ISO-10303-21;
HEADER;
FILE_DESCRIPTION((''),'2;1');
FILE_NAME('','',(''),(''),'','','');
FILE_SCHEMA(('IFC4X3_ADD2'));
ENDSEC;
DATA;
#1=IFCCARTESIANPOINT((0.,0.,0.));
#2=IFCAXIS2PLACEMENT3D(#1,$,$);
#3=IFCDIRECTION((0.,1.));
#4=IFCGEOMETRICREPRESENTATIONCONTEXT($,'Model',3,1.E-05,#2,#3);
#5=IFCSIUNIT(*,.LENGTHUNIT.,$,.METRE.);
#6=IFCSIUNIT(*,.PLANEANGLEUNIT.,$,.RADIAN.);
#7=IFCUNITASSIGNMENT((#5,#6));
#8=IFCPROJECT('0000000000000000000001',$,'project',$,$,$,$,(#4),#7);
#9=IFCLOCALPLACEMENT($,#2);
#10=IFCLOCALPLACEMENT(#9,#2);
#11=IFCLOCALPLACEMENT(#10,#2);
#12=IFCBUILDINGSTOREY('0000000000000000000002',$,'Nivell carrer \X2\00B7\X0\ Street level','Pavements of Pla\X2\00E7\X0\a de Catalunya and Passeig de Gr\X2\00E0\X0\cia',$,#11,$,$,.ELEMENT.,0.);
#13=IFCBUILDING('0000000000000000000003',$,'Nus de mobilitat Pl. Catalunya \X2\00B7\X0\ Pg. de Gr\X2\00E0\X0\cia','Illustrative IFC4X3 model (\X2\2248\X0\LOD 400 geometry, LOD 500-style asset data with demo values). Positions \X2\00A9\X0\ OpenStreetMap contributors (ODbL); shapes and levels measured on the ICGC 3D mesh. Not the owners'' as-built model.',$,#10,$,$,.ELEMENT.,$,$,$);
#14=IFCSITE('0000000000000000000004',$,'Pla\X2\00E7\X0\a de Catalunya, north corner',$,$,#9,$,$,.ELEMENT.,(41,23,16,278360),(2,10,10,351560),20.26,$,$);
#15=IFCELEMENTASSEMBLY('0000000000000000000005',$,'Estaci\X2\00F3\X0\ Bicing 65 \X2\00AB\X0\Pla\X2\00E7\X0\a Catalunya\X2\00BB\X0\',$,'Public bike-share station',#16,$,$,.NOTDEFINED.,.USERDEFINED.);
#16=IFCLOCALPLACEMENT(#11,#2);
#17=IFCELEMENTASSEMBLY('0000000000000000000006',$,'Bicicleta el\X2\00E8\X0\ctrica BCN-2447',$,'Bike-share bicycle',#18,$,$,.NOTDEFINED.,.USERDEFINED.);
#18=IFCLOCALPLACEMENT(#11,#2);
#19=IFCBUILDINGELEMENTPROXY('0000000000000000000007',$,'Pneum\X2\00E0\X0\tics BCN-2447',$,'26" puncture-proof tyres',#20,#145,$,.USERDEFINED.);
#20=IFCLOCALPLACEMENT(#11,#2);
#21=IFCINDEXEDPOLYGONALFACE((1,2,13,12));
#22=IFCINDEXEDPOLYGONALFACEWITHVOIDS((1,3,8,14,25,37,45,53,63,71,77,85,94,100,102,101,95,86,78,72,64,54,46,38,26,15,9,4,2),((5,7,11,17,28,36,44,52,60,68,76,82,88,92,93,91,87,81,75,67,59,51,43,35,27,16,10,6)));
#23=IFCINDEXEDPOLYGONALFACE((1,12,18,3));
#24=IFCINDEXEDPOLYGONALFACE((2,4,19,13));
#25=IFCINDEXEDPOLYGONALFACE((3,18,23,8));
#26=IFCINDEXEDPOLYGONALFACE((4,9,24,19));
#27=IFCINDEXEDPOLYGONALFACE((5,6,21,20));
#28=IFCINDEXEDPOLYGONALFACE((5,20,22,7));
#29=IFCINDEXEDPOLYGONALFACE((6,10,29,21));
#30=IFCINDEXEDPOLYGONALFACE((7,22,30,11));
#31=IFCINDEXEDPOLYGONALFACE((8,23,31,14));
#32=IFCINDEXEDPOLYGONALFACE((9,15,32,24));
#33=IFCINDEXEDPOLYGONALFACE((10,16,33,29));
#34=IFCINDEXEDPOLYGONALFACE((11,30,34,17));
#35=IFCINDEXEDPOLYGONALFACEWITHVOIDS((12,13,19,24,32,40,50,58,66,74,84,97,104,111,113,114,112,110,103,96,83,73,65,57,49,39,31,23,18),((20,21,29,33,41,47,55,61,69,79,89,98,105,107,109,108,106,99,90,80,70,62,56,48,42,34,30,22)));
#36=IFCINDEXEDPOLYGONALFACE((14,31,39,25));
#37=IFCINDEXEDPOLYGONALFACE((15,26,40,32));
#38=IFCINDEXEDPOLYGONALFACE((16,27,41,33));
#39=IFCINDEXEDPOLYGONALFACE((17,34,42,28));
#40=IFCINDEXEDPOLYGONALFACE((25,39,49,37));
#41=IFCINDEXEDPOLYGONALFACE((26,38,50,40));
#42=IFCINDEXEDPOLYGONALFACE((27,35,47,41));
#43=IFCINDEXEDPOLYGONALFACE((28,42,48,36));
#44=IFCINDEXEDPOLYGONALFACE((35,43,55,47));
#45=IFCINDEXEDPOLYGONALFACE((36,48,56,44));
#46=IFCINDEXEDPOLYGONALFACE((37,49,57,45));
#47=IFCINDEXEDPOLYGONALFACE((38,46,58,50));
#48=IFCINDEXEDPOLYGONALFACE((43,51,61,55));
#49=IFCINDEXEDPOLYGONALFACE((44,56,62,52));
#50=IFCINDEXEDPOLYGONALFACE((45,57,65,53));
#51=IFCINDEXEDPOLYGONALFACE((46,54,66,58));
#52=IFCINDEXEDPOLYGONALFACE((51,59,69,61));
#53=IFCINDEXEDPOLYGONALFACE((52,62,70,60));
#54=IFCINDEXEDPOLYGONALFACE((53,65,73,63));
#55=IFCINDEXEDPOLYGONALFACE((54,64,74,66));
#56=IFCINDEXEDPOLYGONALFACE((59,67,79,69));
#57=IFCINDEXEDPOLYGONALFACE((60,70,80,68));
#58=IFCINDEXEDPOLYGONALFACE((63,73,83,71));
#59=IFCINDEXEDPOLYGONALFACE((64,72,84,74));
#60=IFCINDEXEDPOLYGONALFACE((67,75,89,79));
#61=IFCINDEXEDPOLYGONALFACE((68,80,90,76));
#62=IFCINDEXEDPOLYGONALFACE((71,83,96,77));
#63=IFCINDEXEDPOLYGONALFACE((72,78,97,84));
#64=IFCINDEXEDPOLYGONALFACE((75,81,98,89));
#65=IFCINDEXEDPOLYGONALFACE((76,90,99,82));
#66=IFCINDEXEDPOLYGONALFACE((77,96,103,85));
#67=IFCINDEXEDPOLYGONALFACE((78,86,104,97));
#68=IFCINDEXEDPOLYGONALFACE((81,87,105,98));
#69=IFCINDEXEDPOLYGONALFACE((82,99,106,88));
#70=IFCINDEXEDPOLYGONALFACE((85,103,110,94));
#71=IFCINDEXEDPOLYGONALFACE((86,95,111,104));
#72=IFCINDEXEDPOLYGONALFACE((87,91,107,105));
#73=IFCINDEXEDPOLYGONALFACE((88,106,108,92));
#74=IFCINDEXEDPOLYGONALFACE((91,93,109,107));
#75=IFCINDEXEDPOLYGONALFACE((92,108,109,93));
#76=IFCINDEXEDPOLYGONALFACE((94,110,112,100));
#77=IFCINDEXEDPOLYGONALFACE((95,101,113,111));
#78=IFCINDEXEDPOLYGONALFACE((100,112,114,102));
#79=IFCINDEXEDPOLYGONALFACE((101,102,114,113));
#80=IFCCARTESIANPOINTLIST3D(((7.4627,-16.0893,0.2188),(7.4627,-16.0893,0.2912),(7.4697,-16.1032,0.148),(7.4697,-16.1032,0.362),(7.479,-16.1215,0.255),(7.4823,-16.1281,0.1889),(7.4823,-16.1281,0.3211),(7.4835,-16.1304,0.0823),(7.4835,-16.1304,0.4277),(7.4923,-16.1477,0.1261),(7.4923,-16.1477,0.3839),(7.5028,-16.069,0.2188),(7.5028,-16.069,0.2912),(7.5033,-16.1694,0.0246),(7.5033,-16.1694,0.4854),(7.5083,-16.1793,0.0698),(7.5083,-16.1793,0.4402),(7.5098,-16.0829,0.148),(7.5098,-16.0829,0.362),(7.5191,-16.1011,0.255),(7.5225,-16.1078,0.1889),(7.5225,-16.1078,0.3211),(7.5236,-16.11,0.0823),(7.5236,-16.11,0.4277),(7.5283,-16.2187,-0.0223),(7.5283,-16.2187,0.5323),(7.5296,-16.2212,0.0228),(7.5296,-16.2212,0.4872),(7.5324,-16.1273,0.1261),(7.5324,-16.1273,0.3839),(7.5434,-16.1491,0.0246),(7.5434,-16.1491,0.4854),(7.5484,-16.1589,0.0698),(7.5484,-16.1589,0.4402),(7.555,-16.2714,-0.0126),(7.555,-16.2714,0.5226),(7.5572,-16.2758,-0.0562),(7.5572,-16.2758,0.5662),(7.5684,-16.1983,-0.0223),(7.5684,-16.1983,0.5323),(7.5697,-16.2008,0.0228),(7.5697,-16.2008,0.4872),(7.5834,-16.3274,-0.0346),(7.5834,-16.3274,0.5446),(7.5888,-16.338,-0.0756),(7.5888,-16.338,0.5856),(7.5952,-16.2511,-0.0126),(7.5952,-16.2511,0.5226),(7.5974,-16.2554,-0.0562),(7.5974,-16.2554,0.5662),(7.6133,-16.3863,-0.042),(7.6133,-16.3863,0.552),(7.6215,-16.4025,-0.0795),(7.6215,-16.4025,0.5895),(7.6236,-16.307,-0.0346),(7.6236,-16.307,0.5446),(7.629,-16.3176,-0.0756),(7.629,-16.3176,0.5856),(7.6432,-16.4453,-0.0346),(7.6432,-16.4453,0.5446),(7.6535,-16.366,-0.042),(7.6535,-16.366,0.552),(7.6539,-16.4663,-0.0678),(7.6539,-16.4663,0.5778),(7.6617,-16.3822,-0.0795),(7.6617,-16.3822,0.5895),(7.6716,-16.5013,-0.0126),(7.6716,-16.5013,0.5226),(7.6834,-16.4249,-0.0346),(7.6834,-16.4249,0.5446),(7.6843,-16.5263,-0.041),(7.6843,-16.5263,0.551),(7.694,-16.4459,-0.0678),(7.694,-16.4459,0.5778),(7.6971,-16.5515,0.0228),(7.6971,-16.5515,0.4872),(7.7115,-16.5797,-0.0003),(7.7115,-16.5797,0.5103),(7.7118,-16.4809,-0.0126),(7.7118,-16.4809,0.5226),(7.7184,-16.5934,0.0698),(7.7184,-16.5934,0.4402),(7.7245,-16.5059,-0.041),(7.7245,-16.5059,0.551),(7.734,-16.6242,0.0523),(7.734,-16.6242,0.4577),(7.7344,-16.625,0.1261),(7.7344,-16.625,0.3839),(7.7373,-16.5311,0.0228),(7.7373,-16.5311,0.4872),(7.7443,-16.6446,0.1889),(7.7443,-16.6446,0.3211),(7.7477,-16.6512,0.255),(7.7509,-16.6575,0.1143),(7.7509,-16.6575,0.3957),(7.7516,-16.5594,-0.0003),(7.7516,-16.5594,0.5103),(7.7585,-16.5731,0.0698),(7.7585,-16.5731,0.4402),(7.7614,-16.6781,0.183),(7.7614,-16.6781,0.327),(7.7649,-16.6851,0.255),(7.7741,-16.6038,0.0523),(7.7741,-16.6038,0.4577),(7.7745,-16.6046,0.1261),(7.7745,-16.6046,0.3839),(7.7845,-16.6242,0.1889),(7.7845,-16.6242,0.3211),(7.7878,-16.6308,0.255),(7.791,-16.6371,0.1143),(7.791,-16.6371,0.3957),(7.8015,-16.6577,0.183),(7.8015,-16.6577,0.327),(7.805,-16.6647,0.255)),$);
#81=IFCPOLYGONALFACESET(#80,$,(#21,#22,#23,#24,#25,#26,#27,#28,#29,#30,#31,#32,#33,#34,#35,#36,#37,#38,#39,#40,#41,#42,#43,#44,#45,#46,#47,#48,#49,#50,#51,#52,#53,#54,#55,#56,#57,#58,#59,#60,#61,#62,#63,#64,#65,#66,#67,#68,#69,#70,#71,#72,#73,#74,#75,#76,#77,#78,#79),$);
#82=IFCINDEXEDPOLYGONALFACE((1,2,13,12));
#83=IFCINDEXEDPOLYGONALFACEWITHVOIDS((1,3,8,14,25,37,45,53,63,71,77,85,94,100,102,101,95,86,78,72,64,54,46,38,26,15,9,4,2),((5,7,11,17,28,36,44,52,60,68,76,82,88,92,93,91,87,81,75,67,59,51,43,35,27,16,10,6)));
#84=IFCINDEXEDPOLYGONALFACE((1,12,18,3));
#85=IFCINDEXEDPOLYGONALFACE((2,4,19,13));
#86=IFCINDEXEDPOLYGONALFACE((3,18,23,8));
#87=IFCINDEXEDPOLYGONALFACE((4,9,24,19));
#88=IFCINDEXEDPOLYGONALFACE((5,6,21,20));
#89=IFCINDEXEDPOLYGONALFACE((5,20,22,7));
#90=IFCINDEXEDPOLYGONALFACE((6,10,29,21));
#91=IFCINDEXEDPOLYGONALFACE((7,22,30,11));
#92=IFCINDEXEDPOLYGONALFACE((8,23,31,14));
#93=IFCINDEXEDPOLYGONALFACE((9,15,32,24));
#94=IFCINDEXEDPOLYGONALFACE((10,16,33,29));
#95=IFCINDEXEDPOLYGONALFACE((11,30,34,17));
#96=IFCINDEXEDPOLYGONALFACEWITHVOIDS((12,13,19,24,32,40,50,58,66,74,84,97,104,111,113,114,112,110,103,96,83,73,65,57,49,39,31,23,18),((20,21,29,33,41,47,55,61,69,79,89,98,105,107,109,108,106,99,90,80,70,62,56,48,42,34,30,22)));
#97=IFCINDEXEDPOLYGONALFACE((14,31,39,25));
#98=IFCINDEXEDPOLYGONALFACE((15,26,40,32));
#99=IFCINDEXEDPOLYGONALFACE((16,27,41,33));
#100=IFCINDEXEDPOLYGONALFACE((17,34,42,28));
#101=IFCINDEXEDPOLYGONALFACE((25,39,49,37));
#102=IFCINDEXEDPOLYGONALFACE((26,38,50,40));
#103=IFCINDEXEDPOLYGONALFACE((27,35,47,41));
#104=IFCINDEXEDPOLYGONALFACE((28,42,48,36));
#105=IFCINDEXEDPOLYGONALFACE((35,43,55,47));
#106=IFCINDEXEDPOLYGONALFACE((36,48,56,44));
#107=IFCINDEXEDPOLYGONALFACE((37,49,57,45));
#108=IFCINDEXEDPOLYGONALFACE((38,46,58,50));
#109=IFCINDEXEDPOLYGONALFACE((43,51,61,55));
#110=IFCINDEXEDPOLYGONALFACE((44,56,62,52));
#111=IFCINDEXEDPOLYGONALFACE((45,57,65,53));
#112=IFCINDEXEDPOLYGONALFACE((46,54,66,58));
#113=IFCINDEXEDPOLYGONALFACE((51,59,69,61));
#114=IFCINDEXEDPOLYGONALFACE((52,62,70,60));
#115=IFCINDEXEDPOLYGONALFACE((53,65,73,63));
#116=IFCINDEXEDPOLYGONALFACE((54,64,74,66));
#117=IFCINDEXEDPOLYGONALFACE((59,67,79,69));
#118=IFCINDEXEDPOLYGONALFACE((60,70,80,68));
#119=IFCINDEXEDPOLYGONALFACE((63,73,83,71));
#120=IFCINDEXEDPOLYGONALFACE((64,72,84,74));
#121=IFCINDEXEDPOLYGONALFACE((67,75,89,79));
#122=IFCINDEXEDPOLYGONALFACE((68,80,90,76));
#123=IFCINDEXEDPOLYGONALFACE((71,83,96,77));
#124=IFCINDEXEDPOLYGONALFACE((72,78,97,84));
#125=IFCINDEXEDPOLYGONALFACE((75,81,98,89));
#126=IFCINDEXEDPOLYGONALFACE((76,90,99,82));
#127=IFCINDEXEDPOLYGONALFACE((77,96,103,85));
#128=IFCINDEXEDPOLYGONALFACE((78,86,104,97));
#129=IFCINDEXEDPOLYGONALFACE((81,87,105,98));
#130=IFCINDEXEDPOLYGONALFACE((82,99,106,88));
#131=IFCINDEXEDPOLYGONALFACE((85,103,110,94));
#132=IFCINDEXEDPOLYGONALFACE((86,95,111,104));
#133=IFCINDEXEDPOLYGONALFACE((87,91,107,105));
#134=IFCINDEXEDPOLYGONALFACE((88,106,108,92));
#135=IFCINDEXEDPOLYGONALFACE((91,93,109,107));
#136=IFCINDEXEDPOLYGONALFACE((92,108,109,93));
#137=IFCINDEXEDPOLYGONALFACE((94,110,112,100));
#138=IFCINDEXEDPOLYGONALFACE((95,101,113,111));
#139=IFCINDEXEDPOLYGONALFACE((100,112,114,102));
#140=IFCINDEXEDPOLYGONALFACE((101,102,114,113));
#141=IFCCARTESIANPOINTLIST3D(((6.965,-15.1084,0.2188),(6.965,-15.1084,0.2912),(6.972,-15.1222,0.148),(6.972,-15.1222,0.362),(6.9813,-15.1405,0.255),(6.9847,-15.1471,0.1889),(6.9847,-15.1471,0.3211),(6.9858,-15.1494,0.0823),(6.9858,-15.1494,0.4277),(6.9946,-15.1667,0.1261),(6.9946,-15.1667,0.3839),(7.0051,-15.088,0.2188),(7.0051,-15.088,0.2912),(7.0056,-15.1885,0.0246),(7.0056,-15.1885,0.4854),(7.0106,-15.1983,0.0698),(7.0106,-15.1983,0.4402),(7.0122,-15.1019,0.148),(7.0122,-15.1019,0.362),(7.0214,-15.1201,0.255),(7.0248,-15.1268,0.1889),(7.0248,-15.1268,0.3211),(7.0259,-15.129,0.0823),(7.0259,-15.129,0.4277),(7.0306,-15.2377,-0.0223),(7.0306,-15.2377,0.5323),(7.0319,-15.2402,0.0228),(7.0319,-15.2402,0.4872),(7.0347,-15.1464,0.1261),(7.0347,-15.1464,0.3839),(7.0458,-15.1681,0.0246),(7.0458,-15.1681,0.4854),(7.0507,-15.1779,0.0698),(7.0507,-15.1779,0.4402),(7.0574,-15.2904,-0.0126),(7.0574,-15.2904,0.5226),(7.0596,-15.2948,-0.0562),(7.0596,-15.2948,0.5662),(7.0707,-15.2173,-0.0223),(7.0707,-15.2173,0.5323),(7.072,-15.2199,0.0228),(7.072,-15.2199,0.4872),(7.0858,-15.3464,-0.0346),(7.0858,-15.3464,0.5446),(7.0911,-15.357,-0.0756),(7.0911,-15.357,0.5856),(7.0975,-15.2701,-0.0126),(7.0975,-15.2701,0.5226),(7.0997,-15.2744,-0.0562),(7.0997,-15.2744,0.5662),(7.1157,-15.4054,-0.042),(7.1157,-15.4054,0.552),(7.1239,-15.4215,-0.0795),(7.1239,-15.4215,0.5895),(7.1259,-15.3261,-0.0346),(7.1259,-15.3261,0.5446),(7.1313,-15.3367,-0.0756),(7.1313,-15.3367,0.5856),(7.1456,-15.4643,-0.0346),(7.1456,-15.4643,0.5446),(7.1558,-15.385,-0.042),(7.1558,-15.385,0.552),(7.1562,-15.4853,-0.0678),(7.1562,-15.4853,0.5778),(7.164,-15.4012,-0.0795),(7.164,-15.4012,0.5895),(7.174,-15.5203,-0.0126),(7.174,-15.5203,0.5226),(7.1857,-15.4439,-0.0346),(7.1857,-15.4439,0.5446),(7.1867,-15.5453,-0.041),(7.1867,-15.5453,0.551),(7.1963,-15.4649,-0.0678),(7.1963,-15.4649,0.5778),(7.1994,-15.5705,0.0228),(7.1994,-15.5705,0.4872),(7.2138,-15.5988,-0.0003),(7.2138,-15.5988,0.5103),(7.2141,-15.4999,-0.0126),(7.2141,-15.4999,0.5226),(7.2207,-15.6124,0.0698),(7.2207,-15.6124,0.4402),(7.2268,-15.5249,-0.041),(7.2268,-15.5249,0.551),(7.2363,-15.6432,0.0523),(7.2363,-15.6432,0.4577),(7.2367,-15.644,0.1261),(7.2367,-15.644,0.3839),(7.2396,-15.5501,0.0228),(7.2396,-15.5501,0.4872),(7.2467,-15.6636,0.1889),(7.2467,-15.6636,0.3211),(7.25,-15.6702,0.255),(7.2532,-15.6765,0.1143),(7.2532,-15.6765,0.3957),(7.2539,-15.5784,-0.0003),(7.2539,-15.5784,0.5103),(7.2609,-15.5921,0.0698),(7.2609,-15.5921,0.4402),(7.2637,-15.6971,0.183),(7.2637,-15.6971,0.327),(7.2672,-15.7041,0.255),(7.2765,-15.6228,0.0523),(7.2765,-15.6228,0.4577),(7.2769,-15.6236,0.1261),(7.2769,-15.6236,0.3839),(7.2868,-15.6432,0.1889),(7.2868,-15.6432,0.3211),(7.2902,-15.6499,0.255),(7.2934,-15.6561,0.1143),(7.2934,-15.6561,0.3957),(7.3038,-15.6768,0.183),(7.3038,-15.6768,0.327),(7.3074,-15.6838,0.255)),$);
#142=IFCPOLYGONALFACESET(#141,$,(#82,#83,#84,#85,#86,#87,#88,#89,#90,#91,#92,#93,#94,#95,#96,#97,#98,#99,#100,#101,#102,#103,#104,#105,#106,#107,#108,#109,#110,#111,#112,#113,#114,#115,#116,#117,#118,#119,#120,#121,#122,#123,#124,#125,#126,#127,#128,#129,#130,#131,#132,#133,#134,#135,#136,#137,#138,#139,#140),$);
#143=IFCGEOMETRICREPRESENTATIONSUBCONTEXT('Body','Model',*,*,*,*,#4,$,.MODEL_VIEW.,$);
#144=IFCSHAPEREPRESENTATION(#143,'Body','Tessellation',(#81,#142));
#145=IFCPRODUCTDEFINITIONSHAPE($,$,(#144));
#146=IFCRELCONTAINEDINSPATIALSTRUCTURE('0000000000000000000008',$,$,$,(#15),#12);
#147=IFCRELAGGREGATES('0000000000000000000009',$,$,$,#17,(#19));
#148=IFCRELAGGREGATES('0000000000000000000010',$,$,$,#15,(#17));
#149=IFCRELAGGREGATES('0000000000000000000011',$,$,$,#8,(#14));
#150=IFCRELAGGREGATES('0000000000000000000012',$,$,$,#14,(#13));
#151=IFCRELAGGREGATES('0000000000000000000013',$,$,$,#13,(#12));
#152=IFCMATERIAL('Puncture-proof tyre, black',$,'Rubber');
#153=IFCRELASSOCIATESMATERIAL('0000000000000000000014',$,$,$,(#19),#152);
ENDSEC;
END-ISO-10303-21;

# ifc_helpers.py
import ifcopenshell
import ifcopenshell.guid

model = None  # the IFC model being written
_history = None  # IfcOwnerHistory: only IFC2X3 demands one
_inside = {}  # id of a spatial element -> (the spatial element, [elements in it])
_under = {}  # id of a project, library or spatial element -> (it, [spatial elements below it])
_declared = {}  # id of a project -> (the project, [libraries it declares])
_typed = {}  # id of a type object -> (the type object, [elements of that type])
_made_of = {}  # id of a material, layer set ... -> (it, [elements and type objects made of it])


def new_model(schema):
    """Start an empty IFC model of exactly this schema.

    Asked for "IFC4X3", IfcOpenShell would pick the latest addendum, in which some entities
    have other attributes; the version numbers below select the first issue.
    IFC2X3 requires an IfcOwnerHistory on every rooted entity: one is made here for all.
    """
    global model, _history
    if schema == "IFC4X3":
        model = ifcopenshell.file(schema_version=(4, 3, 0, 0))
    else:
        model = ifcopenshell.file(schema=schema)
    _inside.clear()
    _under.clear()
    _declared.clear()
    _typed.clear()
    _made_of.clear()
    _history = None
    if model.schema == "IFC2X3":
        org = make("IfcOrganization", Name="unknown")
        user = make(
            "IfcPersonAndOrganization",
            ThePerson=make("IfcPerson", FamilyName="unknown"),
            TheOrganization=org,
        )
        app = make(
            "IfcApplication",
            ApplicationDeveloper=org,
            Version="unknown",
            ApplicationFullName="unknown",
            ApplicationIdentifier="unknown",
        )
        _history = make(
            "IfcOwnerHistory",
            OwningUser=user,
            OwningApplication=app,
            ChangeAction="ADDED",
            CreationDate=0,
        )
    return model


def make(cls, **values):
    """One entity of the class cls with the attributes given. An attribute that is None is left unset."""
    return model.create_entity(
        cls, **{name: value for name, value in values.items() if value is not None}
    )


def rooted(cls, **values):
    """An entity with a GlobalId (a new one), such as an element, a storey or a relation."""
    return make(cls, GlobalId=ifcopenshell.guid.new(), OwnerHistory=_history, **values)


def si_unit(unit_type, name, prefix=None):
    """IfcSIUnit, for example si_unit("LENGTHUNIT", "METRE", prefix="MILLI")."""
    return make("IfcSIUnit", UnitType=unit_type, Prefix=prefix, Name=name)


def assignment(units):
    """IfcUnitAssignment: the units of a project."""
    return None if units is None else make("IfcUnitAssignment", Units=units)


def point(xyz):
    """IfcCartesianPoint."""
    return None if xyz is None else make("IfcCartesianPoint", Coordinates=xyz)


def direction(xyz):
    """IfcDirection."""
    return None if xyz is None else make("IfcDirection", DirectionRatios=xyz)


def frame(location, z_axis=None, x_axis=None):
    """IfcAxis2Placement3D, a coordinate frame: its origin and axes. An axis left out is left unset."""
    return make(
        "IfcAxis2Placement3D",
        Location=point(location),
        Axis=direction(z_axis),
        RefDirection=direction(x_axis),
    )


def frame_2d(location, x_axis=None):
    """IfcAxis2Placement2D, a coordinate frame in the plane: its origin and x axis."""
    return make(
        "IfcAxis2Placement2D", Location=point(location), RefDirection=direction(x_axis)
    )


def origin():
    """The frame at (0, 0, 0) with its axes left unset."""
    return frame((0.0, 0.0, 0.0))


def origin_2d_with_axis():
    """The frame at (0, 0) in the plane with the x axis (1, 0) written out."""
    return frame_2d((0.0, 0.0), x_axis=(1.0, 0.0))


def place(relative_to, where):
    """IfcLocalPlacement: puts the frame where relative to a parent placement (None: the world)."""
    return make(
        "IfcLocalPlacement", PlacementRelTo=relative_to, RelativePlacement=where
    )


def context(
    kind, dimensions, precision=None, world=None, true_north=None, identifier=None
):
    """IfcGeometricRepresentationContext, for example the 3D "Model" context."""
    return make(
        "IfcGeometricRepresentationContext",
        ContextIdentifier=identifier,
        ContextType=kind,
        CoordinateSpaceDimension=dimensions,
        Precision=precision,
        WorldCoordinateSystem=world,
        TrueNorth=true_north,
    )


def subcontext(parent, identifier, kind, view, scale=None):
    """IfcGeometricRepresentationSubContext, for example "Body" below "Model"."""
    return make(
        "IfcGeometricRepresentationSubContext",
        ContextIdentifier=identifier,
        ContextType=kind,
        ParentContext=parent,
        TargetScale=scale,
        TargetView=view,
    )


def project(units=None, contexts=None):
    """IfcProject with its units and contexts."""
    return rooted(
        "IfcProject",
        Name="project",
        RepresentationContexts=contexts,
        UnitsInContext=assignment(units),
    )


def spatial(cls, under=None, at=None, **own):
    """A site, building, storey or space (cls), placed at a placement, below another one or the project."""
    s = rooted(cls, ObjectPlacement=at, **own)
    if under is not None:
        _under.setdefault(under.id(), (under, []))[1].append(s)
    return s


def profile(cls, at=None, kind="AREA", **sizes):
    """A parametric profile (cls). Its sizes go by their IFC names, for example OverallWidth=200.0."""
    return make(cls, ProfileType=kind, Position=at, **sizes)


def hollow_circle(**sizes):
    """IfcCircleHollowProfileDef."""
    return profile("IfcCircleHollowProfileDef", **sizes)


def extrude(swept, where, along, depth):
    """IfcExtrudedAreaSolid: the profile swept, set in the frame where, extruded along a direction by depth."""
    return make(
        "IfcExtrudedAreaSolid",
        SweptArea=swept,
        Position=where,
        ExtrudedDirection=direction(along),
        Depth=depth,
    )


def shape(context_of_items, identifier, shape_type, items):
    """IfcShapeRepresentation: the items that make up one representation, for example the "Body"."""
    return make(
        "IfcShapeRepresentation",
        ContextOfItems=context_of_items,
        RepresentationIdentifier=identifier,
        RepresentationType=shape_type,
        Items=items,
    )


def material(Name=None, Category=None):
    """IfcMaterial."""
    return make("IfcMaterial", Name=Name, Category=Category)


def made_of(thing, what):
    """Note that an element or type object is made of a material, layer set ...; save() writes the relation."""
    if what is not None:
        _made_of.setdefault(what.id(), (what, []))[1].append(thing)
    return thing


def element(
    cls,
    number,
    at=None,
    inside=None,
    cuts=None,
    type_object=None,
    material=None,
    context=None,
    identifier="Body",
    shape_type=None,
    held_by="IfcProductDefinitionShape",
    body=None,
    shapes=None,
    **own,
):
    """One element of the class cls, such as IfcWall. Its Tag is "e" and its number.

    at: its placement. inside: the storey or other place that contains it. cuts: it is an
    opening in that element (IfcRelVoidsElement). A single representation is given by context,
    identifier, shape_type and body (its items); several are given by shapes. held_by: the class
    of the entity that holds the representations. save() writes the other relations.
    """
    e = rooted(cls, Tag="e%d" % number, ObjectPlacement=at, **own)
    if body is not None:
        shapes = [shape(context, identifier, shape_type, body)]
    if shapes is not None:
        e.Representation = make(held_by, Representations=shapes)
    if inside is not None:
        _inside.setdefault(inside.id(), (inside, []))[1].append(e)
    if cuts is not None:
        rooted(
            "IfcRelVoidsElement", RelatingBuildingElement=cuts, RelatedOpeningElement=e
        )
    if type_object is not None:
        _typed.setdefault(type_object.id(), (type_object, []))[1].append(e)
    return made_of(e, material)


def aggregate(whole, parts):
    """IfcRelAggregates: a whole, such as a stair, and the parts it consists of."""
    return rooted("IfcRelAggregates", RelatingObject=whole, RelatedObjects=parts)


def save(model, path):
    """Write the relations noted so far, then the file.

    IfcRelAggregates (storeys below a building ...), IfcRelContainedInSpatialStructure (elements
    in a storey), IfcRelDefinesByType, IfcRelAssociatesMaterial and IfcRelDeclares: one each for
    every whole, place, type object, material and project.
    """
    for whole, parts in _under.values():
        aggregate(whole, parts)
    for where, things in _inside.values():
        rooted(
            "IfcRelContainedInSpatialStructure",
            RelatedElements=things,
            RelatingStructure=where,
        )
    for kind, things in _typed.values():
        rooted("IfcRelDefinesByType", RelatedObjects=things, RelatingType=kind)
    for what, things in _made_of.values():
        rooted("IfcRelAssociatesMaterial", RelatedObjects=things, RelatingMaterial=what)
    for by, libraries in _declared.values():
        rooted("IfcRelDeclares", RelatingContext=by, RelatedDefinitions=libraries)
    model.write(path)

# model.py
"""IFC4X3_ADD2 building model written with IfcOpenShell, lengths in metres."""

from ifc_helpers import new_model, si_unit, direction, frame, origin, origin_2d_with_axis, place, context, subcontext, project, spatial, hollow_circle, extrude, material, element, aggregate, save


model = new_model("IFC4X3_ADD2")

# Units and contexts
model_context = context("Model", 3, precision=1e-05, world=origin(), true_north=direction((0.0, 1.0)))
body_context = subcontext(model_context, "Body", "Model", "MODEL_VIEW")
ifc_project = project(units=[si_unit("LENGTHUNIT", "METRE"), si_unit("PLANEANGLEUNIT", "RADIAN")], contexts=[model_context])

# Site, building, storey
site_placement = place(None, origin())
site = spatial("IfcSite", under=ifc_project, at=site_placement, Name="Plaça de Catalunya, north corner", CompositionType="ELEMENT", RefLatitude=(41, 23, 16, 278360), RefLongitude=(2, 10, 10, 351560), RefElevation=20.26)
building_placement = place(site_placement, origin())
building = spatial("IfcBuilding", under=site, at=building_placement, Name="Nus de mobilitat Pl. Catalunya · Pg. de Gràcia", Description="Illustrative IFC4X3 model (≈LOD 400 geometry, LOD 500-style asset data with demo values). Positions © OpenStreetMap contributors (ODbL); shapes and levels measured on the ICGC 3D mesh. Not the owners' as-built model.", CompositionType="ELEMENT")
storey_placement = place(building_placement, origin())
storey = spatial("IfcBuildingStorey", under=building, at=storey_placement, Name="Nivell carrer · Street level", Description="Pavements of Plaça de Catalunya and Passeig de Gràcia", CompositionType="ELEMENT", Elevation=0.0)

# Element assemblies, building element proxy
assembly_1_placement = place(building_placement, origin())
assembly_1 = element("IfcElementAssembly", 1, at=assembly_1_placement, inside=storey, Name="Estació Bicing 65 «Plaça Catalunya»", ObjectType="Public bike-share station", AssemblyPlace="NOTDEFINED", PredefinedType="USERDEFINED")
assembly_2_placement = place(building_placement, origin())
assembly_2 = element("IfcElementAssembly", 2, at=assembly_2_placement, Name="Bicicleta elèctrica BCN-2447", ObjectType="Bike-share bicycle", AssemblyPlace="NOTDEFINED", PredefinedType="USERDEFINED")
ifc_material_1 = material(Name="Puncture-proof tyre, black", Category="Rubber")
proxy_1_placement = place(building_placement, origin())
proxy_1 = element("IfcBuildingElementProxy", 3, at=proxy_1_placement, material=ifc_material_1, Name="Pneumàtics BCN-2447", ObjectType="26\" puncture-proof tyres", PredefinedType="USERDEFINED", context=body_context, shape_type="SweptSolid", body=[
    extrude(hollow_circle(Radius=0.335, WallThickness=0.038, at=origin_2d_with_axis()), frame((7.6133, -16.3863, 0.255), z_axis=(0.891798, 0.452435, 0.0), x_axis=(0.452435, -0.891798, 0.0)), (0.0, 0.0, 1.0), 0.045),
    extrude(hollow_circle(Radius=0.335, WallThickness=0.038, at=origin_2d_with_axis()), frame((7.1157, -15.4054, 0.255), z_axis=(0.891798, 0.452435, 0.0), x_axis=(0.452435, -0.891798, 0.0)), (0.0, 0.0, 1.0), 0.045),
])
aggregate(assembly_2, [proxy_1])
aggregate(assembly_1, [assembly_2])

save(model, "model.ifc")
